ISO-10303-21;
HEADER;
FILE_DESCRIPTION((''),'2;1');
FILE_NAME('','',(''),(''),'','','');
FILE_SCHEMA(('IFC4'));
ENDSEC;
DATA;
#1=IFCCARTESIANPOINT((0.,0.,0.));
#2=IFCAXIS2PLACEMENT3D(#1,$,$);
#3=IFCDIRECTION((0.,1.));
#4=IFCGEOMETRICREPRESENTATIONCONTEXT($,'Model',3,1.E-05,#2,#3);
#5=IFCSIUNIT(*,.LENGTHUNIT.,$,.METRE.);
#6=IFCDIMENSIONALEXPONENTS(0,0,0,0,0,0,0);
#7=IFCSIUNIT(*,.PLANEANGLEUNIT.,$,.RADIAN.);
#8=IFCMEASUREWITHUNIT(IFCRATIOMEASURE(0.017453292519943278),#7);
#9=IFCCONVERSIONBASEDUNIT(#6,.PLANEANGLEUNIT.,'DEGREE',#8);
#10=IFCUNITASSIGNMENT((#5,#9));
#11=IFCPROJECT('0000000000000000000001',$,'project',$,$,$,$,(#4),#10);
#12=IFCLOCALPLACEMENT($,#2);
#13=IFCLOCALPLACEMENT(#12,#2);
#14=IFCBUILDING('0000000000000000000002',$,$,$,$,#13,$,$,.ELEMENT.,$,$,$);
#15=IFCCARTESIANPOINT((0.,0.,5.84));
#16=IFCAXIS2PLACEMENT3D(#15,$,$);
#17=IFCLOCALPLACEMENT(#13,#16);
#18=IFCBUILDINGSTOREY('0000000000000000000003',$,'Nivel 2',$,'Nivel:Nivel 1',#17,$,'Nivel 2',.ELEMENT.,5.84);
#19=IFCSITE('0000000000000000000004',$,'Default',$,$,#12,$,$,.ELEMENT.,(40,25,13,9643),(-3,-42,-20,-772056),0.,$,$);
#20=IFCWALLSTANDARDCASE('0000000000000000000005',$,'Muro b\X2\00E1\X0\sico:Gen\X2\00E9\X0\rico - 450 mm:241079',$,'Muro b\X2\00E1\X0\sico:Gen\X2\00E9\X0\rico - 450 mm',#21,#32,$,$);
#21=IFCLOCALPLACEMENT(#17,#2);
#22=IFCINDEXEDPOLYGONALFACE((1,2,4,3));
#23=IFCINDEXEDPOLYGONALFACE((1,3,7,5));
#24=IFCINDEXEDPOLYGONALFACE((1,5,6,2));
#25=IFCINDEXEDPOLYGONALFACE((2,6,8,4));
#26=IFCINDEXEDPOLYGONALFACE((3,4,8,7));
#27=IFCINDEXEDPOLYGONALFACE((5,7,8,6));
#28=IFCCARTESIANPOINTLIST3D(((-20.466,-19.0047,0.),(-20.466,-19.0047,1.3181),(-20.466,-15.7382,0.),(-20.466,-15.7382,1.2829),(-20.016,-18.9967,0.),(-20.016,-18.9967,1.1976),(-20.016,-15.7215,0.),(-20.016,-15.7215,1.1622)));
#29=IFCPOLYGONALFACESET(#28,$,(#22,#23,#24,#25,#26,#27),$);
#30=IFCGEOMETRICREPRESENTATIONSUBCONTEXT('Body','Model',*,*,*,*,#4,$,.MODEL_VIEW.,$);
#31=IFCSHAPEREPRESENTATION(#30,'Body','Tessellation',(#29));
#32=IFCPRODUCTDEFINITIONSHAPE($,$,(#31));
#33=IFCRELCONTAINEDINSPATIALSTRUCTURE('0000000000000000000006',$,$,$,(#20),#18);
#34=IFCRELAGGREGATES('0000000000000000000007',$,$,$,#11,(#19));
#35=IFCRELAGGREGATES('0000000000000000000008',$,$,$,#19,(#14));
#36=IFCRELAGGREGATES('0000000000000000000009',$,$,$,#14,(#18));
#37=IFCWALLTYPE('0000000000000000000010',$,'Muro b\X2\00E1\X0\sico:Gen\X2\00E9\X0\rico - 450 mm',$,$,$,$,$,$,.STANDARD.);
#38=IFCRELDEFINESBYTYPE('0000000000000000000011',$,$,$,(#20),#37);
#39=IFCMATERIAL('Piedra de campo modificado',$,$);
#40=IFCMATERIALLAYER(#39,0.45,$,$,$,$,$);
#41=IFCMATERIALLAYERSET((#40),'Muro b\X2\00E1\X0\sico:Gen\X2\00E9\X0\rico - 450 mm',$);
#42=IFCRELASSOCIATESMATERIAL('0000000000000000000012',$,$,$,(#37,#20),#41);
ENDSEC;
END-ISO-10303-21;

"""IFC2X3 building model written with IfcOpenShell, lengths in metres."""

from ifc_helpers import new_model, entity, si_unit, converted_unit, direction, frame, origin, place, context, subcontext, project, spatial, polyline, outline, extrude, clip, bounded_halfspace, material, layer, layer_set, layer_usage, type_object, element, save


model = new_model("IFC2X3")

# Units and contexts
model_context = context("Model", 3, precision=1e-05, world=origin(), true_north=direction((0.0, 1.0)))
body_context = subcontext(model_context, "Body", "Model", "MODEL_VIEW")
ifc_project = project(units=[si_unit("LENGTHUNIT", "METRE"), converted_unit("PLANEANGLEUNIT", "DEGREE", entity("IfcRatioMeasure", 0.017453292519943278), si_unit("PLANEANGLEUNIT", "RADIAN"), dimensions=[0, 0, 0, 0, 0, 0, 0])], contexts=[model_context])

# Site, building, storey
site_placement = place(None, origin())
site = spatial("IfcSite", under=ifc_project, at=site_placement, Name="Default", CompositionType="ELEMENT", RefLatitude=(40, 25, 13, 9643), RefLongitude=(-3, -42, -20, -772056), RefElevation=0.0)
building_placement = place(site_placement, origin())
building = spatial("IfcBuilding", under=site, at=building_placement, CompositionType="ELEMENT")
storey_placement = place(building_placement, frame((0.0, 0.0, 5.84)))
storey = spatial("IfcBuildingStorey", under=building, at=storey_placement, Name="Nivel 2", ObjectType="Nivel:Nivel 1", LongName="Nivel 2", CompositionType="ELEMENT", Elevation=5.84)

# Wall
ifc_material = material(Name="Piedra de campo modificado")
ifc_layer = layer(ifc_material, 0.45)
ifc_layer_set = layer_set([ifc_layer], Name="Muro básico:Genérico - 450 mm")
ifc_layer_usage = layer_usage(ifc_layer_set, "AXIS2", "NEGATIVE", 0.225)
wall_type = type_object("IfcWallType", Name="Muro básico:Genérico - 450 mm", PredefinedType="STANDARD", material=ifc_layer_set)
wall_placement = place(storey_placement, frame((-20.241, -15.7215, 0.0), z_axis=(0.0, 0.0, 1.0), x_axis=(0.0, -1.0, 0.0)))
element("IfcWallStandardCase", 1, at=wall_placement, inside=storey, type_object=wall_type, material=ifc_layer_usage, Name="Muro básico:Genérico - 450 mm:241079", ObjectType="Muro básico:Genérico - 450 mm", context=body_context, shape_type="Clipping", body=[
    clip(extrude(outline(polyline([(3.2832, -0.225), (3.2752, 0.225), (0.0, 0.225), (0.0167, -0.225), (3.2832, -0.225)])), origin(), (0.0, 0.0, 1.0), 1.3181), bounded_halfspace(frame((0.0167, -0.225, 1.2829), z_axis=(-0.010422, 0.258609, 0.965926), x_axis=(-0.999189, -0.040268, 0.0)), False, frame((0.0167, -0.225, 1.2829)), polyline([(0.0, 0.0), (3.2665, 0.0), (3.2585, 0.45), (-0.0167, 0.45), (0.0, 0.0)]))),
])

save(model, "model.ifc")
